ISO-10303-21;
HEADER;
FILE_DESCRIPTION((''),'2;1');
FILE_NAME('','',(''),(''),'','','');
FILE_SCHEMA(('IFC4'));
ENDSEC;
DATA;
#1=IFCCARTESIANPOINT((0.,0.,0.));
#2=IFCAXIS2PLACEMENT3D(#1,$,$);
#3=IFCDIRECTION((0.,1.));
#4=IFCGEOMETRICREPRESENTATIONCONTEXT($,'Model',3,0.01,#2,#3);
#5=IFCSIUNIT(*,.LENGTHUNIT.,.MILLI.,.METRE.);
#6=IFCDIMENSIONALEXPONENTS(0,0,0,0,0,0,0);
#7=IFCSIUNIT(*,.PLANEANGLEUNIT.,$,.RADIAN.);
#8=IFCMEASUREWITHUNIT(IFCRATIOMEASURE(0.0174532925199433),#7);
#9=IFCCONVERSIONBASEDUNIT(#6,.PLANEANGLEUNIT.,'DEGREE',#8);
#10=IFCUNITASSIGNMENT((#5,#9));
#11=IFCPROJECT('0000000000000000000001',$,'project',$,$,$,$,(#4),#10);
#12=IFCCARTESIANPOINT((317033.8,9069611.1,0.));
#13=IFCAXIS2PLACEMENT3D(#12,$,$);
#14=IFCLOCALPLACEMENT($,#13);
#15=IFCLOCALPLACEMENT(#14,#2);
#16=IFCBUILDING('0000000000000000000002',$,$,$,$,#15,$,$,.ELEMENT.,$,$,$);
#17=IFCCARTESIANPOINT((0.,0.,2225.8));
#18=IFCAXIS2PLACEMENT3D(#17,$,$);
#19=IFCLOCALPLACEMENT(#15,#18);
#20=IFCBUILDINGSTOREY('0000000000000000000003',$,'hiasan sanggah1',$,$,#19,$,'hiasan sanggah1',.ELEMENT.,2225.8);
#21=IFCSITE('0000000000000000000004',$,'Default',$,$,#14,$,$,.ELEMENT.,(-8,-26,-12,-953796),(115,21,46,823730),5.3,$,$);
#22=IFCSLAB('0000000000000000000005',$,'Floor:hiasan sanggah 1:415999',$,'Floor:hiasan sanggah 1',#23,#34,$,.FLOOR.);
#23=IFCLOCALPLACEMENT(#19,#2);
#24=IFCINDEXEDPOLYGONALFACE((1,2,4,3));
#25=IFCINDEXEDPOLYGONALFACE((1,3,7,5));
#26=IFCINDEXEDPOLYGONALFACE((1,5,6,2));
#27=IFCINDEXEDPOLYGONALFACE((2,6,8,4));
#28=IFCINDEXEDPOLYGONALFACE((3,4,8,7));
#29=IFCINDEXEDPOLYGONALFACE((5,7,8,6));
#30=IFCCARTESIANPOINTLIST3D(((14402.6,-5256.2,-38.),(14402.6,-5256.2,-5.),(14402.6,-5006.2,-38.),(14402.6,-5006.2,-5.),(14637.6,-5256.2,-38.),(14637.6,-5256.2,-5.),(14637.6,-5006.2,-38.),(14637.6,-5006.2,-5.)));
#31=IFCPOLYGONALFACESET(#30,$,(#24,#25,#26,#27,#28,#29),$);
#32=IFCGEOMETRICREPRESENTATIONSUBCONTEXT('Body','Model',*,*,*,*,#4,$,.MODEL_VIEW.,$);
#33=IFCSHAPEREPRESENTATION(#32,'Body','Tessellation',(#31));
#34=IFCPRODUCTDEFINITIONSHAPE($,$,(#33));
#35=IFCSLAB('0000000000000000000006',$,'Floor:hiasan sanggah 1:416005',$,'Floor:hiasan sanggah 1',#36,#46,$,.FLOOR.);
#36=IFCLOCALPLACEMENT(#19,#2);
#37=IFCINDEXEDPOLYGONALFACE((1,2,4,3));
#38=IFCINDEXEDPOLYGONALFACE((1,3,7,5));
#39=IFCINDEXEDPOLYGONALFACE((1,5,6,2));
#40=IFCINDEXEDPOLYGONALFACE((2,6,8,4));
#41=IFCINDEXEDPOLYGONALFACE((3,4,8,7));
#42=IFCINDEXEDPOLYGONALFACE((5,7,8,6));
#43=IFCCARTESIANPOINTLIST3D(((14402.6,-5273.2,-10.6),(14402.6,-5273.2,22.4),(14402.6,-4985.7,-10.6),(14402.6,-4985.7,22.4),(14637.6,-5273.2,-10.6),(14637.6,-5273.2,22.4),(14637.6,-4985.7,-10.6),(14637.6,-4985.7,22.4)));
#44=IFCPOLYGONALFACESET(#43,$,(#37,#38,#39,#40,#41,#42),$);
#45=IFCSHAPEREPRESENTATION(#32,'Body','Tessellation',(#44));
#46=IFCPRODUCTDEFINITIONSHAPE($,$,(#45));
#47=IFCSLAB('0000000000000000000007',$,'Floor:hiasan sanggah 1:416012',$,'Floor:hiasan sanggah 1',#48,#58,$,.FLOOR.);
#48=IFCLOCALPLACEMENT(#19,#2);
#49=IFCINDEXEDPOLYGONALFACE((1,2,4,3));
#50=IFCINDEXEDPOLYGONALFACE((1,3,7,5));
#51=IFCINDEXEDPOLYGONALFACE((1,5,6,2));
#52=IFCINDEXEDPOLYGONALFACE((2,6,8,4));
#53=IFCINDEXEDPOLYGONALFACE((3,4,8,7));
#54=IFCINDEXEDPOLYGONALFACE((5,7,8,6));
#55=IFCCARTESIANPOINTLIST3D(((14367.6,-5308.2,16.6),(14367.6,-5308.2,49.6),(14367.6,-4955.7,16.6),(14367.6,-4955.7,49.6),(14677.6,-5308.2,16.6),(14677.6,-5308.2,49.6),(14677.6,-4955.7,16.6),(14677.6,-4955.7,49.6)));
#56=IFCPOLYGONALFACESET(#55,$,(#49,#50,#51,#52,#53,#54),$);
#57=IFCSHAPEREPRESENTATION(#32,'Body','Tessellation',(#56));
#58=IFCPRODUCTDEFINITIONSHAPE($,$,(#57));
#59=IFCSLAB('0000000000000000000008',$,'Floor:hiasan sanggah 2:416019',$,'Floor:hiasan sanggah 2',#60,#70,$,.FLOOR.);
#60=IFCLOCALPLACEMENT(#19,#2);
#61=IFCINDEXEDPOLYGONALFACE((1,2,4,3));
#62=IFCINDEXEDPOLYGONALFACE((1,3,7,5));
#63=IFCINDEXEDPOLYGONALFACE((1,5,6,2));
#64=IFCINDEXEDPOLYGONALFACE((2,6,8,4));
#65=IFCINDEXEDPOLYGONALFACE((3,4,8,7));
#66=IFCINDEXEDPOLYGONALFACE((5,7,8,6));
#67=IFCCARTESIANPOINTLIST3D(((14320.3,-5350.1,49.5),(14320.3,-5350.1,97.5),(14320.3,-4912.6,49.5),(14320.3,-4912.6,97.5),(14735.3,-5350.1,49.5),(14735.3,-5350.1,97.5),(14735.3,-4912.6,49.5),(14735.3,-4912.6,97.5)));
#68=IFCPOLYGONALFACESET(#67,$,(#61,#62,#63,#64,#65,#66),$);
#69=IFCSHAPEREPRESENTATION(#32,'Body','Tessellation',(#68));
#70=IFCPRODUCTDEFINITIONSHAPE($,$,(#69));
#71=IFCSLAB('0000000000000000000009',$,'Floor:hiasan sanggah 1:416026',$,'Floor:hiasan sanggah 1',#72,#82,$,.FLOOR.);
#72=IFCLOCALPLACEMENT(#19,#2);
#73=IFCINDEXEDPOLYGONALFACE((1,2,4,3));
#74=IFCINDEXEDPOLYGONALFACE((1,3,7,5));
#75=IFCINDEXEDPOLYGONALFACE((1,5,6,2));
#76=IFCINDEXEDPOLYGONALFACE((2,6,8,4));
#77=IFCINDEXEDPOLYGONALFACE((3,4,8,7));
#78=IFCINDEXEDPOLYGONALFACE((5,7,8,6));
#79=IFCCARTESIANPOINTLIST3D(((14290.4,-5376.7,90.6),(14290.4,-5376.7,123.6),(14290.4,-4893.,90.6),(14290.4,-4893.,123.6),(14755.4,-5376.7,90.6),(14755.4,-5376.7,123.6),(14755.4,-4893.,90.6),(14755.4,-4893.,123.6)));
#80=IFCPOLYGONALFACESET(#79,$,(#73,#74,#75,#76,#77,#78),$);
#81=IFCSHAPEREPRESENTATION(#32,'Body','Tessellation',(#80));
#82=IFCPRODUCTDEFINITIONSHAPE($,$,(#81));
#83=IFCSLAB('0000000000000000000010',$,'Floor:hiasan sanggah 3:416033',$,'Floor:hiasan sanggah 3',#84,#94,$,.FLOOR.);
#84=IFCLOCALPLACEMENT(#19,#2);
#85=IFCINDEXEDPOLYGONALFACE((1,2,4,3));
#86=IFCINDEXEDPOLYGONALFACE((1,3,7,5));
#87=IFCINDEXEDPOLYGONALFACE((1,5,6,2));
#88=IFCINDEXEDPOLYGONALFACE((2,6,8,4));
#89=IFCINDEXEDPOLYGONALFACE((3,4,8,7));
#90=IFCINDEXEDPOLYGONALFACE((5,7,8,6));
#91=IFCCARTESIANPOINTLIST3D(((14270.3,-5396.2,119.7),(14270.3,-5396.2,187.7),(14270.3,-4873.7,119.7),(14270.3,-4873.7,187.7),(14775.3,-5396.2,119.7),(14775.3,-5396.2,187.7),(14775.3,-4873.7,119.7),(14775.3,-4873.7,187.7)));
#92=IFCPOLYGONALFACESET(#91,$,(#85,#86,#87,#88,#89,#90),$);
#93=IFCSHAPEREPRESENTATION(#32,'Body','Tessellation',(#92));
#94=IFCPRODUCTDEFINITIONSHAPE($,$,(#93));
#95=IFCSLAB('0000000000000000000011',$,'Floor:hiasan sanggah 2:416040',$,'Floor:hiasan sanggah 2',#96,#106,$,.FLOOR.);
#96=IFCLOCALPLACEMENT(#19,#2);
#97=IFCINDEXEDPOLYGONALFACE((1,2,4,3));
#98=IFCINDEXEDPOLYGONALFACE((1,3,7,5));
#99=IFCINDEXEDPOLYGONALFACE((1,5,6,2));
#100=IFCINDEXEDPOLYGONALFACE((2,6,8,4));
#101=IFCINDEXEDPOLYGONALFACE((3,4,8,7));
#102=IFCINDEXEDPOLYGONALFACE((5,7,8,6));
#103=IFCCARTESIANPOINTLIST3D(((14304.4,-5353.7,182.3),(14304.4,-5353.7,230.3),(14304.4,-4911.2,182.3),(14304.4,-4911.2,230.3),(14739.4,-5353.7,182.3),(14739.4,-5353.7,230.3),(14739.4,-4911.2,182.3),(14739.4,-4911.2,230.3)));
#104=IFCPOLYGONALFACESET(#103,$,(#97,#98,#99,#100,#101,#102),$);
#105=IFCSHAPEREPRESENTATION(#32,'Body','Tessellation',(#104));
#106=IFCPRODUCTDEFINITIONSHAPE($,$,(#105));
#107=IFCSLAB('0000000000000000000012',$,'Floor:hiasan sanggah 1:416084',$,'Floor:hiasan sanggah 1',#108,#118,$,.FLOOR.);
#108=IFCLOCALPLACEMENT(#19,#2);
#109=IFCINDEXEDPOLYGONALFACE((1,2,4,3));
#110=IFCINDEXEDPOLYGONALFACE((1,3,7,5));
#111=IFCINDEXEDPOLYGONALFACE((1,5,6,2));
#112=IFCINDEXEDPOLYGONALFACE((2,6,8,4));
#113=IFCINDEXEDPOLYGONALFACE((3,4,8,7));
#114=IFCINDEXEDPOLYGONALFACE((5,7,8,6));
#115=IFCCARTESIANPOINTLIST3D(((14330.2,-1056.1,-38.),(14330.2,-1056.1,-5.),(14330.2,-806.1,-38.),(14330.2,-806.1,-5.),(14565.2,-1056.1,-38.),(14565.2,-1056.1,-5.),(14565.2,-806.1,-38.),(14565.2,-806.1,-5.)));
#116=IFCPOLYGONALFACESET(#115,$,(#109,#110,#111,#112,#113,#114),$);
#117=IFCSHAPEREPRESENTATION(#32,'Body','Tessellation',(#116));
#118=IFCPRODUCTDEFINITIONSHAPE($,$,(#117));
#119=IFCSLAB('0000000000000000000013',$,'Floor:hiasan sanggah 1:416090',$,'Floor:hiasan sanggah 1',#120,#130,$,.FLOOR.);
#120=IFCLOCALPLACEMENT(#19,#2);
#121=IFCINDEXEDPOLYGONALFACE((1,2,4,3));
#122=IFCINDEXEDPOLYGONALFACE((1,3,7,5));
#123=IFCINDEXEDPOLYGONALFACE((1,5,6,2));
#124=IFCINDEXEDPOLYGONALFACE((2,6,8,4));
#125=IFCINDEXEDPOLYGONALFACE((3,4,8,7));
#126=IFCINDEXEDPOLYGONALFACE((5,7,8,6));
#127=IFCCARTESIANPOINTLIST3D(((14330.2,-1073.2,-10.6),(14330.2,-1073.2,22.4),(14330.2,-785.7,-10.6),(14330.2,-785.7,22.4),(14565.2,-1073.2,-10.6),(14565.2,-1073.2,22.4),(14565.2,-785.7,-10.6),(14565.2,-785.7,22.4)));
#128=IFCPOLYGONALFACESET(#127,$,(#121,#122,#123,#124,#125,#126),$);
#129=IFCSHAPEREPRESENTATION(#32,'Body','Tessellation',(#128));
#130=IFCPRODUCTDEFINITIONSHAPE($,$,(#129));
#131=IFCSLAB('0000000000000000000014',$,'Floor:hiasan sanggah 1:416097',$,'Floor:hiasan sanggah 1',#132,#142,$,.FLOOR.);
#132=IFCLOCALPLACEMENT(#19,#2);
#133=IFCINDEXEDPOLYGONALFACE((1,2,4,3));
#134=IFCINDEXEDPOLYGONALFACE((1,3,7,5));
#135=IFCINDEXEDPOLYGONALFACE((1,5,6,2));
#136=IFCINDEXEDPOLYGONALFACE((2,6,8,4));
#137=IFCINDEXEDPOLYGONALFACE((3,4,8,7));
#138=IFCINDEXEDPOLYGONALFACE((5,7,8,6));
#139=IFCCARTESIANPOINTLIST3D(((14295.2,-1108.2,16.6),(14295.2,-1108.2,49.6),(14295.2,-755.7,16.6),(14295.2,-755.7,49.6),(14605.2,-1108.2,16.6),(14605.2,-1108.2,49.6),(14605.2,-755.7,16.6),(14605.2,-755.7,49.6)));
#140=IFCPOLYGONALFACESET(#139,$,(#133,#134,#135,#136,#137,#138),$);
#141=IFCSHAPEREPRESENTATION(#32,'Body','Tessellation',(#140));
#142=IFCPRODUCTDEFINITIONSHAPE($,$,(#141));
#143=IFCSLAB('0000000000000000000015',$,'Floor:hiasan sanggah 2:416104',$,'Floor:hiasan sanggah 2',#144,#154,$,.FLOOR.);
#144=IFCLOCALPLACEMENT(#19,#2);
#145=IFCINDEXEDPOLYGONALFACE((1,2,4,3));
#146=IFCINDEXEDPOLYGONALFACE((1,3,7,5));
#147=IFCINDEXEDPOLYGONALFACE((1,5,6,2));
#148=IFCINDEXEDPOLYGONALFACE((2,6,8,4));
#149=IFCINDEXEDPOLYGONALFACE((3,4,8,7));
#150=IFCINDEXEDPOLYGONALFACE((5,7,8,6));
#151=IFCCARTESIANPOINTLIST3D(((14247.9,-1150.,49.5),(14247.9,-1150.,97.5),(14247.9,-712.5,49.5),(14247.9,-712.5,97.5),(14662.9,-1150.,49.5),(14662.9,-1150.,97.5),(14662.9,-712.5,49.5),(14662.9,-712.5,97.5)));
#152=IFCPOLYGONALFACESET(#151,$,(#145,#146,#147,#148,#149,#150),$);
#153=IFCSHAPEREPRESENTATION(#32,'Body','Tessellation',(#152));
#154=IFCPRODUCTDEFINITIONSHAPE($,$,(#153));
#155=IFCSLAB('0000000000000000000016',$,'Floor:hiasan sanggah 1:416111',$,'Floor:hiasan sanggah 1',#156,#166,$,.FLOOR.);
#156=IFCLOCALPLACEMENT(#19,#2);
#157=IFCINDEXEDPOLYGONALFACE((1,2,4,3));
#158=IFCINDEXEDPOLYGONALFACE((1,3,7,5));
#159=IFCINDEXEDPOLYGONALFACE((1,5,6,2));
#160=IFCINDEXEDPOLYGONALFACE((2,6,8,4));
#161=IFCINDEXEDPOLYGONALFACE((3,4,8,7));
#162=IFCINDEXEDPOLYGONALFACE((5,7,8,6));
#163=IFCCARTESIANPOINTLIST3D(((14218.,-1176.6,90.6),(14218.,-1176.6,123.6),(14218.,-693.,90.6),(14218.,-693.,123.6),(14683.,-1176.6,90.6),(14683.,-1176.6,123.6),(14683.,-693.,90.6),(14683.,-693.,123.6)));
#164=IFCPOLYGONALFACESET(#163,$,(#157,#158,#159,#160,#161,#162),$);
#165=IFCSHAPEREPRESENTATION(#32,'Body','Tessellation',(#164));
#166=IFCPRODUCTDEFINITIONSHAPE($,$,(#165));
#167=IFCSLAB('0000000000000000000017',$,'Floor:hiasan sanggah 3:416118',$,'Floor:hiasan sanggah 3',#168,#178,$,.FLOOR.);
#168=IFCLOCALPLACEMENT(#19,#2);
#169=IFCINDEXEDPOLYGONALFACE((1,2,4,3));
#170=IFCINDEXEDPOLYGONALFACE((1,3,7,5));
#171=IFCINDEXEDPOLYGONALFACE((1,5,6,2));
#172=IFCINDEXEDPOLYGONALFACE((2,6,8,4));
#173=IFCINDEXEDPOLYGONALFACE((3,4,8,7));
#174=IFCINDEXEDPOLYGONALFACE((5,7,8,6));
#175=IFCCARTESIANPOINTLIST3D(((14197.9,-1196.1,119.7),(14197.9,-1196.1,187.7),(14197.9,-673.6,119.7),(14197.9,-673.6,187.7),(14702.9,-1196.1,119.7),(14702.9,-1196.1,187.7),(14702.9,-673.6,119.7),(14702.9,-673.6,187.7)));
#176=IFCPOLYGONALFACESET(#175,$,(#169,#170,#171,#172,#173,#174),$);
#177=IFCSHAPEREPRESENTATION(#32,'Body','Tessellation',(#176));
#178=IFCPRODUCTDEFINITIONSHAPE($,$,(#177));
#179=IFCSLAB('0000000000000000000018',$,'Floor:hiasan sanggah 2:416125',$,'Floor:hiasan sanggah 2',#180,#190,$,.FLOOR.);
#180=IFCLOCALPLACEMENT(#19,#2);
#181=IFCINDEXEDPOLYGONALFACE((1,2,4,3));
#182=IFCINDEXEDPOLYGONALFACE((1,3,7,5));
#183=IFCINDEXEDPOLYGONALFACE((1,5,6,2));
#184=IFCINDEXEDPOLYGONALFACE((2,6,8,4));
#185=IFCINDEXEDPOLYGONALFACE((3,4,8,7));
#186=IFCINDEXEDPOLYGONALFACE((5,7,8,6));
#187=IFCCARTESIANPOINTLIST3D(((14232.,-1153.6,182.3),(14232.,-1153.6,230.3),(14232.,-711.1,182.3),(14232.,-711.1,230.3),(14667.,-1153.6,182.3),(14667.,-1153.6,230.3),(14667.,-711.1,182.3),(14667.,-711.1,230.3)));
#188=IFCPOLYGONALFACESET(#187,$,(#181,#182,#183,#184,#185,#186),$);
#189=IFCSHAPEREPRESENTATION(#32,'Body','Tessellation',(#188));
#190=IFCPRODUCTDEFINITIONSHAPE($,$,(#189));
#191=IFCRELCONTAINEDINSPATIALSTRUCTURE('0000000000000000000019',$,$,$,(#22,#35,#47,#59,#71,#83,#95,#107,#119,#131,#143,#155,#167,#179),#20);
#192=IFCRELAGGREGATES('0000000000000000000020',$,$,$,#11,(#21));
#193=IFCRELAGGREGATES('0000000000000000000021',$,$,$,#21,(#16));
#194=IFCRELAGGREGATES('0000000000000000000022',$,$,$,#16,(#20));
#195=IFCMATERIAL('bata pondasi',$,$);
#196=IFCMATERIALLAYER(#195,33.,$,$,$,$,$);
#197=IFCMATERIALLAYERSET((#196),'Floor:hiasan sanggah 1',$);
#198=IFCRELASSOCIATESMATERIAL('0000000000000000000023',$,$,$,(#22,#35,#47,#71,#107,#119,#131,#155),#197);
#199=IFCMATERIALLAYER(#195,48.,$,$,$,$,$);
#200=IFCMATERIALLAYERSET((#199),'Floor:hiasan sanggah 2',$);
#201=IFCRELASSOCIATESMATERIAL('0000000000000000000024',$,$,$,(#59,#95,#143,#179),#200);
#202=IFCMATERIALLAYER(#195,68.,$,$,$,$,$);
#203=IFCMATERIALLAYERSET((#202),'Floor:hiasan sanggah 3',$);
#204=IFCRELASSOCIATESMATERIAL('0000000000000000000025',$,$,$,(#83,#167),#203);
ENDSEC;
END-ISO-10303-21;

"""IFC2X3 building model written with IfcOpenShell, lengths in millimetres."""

from ifc_helpers import new_model, entity, si_unit, converted_unit, direction, frame, frame_2d, origin, origin_2d_with_axis, place, context, subcontext, project, spatial, rectangle, extrude, material, layer, layer_set, layer_usage, element, save


model = new_model("IFC2X3")

# Units and contexts
model_context = context("Model", 3, precision=0.01, world=origin(), true_north=direction((0.0, 1.0)))
body_context = subcontext(model_context, "Body", "Model", "MODEL_VIEW")
ifc_project = project(units=[si_unit("LENGTHUNIT", "METRE", prefix="MILLI"), converted_unit("PLANEANGLEUNIT", "DEGREE", entity("IfcRatioMeasure", 0.0174532925199433), si_unit("PLANEANGLEUNIT", "RADIAN"), dimensions=[0, 0, 0, 0, 0, 0, 0])], contexts=[model_context])

# Site, building, storey
site_placement = place(None, frame((317033.8, 9069611.1, 0.0)))
site = spatial("IfcSite", under=ifc_project, at=site_placement, Name="Default", CompositionType="ELEMENT", RefLatitude=(-8, -26, -12, -953796), RefLongitude=(115, 21, 46, 823730), RefElevation=5.3)
building_placement = place(site_placement, origin())
building = spatial("IfcBuilding", under=site, at=building_placement, CompositionType="ELEMENT")
storey_placement = place(building_placement, frame((0.0, 0.0, 2225.8)))
storey = spatial("IfcBuildingStorey", under=building, at=storey_placement, Name="hiasan sanggah1", LongName="hiasan sanggah1", CompositionType="ELEMENT", Elevation=2225.8)

# Slabs
ifc_material = material(Name="bata pondasi")
ifc_layer_1 = layer(ifc_material, 33.0)
ifc_layer_set_1 = layer_set([ifc_layer_1], Name="Floor:hiasan sanggah 1")
ifc_layer_2 = layer(ifc_material, 48.0)
ifc_layer_set_2 = layer_set([ifc_layer_2], Name="Floor:hiasan sanggah 2")
ifc_layer_3 = layer(ifc_material, 68.0)
ifc_layer_set_3 = layer_set([ifc_layer_3], Name="Floor:hiasan sanggah 3")
ifc_layer_usage_1 = layer_usage(ifc_layer_set_1, "AXIS3", "POSITIVE", 0.0)
slab_1_placement = place(storey_placement, origin())
element("IfcSlab", 1, at=slab_1_placement, inside=storey, material=ifc_layer_usage_1, Name="Floor:hiasan sanggah 1:415999", ObjectType="Floor:hiasan sanggah 1", PredefinedType="FLOOR", context=body_context, shape_type="SweptSolid", body=[
    extrude(rectangle(XDim=250.0, YDim=235.0, at=frame_2d((0.0, 0.0), x_axis=(1.0, 0.0))), frame((14520.1, -5131.2, -5.0), z_axis=(0.0, 0.0, -1.0), x_axis=(0.0, 1.0, 0.0)), (0.0, 0.0, 1.0), 33.0),
])
ifc_layer_usage_2 = layer_usage(ifc_layer_set_1, "AXIS3", "POSITIVE", 0.0)
slab_2_placement = place(storey_placement, origin())
element("IfcSlab", 2, at=slab_2_placement, inside=storey, material=ifc_layer_usage_2, Name="Floor:hiasan sanggah 1:416005", ObjectType="Floor:hiasan sanggah 1", PredefinedType="FLOOR", context=body_context, shape_type="SweptSolid", body=[
    extrude(rectangle(XDim=287.5, YDim=235.0, at=frame_2d((0.0, 0.0), x_axis=(1.0, 0.0))), frame((14520.1, -5129.5, 22.4), z_axis=(0.0, 0.0, -1.0), x_axis=(0.0, 1.0, 0.0)), (0.0, 0.0, 1.0), 33.0),
])
ifc_layer_usage_3 = layer_usage(ifc_layer_set_1, "AXIS3", "POSITIVE", 0.0)
slab_3_placement = place(storey_placement, origin())
element("IfcSlab", 3, at=slab_3_placement, inside=storey, material=ifc_layer_usage_3, Name="Floor:hiasan sanggah 1:416012", ObjectType="Floor:hiasan sanggah 1", PredefinedType="FLOOR", context=body_context, shape_type="SweptSolid", body=[
    extrude(rectangle(XDim=352.5, YDim=310.0, at=origin_2d_with_axis()), frame((14522.6, -5132.0, 49.6), z_axis=(0.0, 0.0, -1.0), x_axis=(0.0, 1.0, 0.0)), (0.0, 0.0, 1.0), 33.0),
])
ifc_layer_usage_4 = layer_usage(ifc_layer_set_2, "AXIS3", "POSITIVE", 0.0)
slab_4_placement = place(storey_placement, origin())
element("IfcSlab", 4, at=slab_4_placement, inside=storey, material=ifc_layer_usage_4, Name="Floor:hiasan sanggah 2:416019", ObjectType="Floor:hiasan sanggah 2", PredefinedType="FLOOR", context=body_context, shape_type="SweptSolid", body=[
    extrude(rectangle(XDim=437.5, YDim=415.0, at=frame_2d((0.0, 0.0), x_axis=(1.0, 0.0))), frame((14527.8, -5131.3, 97.5), z_axis=(0.0, 0.0, -1.0), x_axis=(0.0, 1.0, 0.0)), (0.0, 0.0, 1.0), 48.0),
])
ifc_layer_usage_5 = layer_usage(ifc_layer_set_1, "AXIS3", "POSITIVE", 0.0)
slab_5_placement = place(storey_placement, origin())
element("IfcSlab", 5, at=slab_5_placement, inside=storey, material=ifc_layer_usage_5, Name="Floor:hiasan sanggah 1:416026", ObjectType="Floor:hiasan sanggah 1", PredefinedType="FLOOR", context=body_context, shape_type="SweptSolid", body=[
    extrude(rectangle(XDim=483.7, YDim=465.0, at=frame_2d((0.0, 0.0), x_axis=(1.0, 0.0))), frame((14522.9, -5134.9, 123.6), z_axis=(0.0, 0.0, -1.0), x_axis=(0.0, 1.0, 0.0)), (0.0, 0.0, 1.0), 33.0),
])
ifc_layer_usage_6 = layer_usage(ifc_layer_set_3, "AXIS3", "POSITIVE", 0.0)
slab_6_placement = place(storey_placement, origin())
element("IfcSlab", 6, at=slab_6_placement, inside=storey, material=ifc_layer_usage_6, Name="Floor:hiasan sanggah 3:416033", ObjectType="Floor:hiasan sanggah 3", PredefinedType="FLOOR", context=body_context, shape_type="SweptSolid", body=[
    extrude(rectangle(XDim=522.5, YDim=505.0, at=origin_2d_with_axis()), frame((14522.8, -5134.9, 187.7), z_axis=(0.0, 0.0, -1.0), x_axis=(0.0, 1.0, 0.0)), (0.0, 0.0, 1.0), 68.0),
])
ifc_layer_usage_7 = layer_usage(ifc_layer_set_2, "AXIS3", "POSITIVE", 0.0)
slab_7_placement = place(storey_placement, origin())
element("IfcSlab", 7, at=slab_7_placement, inside=storey, material=ifc_layer_usage_7, Name="Floor:hiasan sanggah 2:416040", ObjectType="Floor:hiasan sanggah 2", PredefinedType="FLOOR", context=body_context, shape_type="SweptSolid", body=[
    extrude(rectangle(XDim=442.5, YDim=435.0, at=origin_2d_with_axis()), frame((14521.9, -5132.4, 230.3), z_axis=(0.0, 0.0, -1.0), x_axis=(0.0, 1.0, 0.0)), (0.0, 0.0, 1.0), 48.0),
])
ifc_layer_usage_8 = layer_usage(ifc_layer_set_1, "AXIS3", "POSITIVE", 0.0)
slab_8_placement = place(storey_placement, origin())
element("IfcSlab", 8, at=slab_8_placement, inside=storey, material=ifc_layer_usage_8, Name="Floor:hiasan sanggah 1:416084", ObjectType="Floor:hiasan sanggah 1", PredefinedType="FLOOR", context=body_context, shape_type="SweptSolid", body=[
    extrude(rectangle(XDim=250.0, YDim=235.0, at=origin_2d_with_axis()), frame((14447.7, -931.1, -5.0), z_axis=(0.0, 0.0, -1.0), x_axis=(0.0, 1.0, 0.0)), (0.0, 0.0, 1.0), 33.0),
])
ifc_layer_usage_9 = layer_usage(ifc_layer_set_1, "AXIS3", "POSITIVE", 0.0)
slab_9_placement = place(storey_placement, origin())
element("IfcSlab", 9, at=slab_9_placement, inside=storey, material=ifc_layer_usage_9, Name="Floor:hiasan sanggah 1:416090", ObjectType="Floor:hiasan sanggah 1", PredefinedType="FLOOR", context=body_context, shape_type="SweptSolid", body=[
    extrude(rectangle(XDim=287.5, YDim=235.0, at=frame_2d((0.0, 0.0), x_axis=(1.0, 0.0))), frame((14447.7, -929.4, 22.4), z_axis=(0.0, 0.0, -1.0), x_axis=(0.0, 1.0, 0.0)), (0.0, 0.0, 1.0), 33.0),
])
ifc_layer_usage_10 = layer_usage(ifc_layer_set_1, "AXIS3", "POSITIVE", 0.0)
slab_10_placement = place(storey_placement, origin())
element("IfcSlab", 10, at=slab_10_placement, inside=storey, material=ifc_layer_usage_10, Name="Floor:hiasan sanggah 1:416097", ObjectType="Floor:hiasan sanggah 1", PredefinedType="FLOOR", context=body_context, shape_type="SweptSolid", body=[
    extrude(rectangle(XDim=352.5, YDim=310.0, at=origin_2d_with_axis()), frame((14450.2, -931.9, 49.6), z_axis=(0.0, 0.0, -1.0), x_axis=(0.0, 1.0, 0.0)), (0.0, 0.0, 1.0), 33.0),
])
ifc_layer_usage_11 = layer_usage(ifc_layer_set_2, "AXIS3", "POSITIVE", 0.0)
slab_11_placement = place(storey_placement, origin())
element("IfcSlab", 11, at=slab_11_placement, inside=storey, material=ifc_layer_usage_11, Name="Floor:hiasan sanggah 2:416104", ObjectType="Floor:hiasan sanggah 2", PredefinedType="FLOOR", context=body_context, shape_type="SweptSolid", body=[
    extrude(rectangle(XDim=437.5, YDim=415.0, at=frame_2d((0.0, 0.0), x_axis=(1.0, 0.0))), frame((14455.4, -931.3, 97.5), z_axis=(0.0, 0.0, -1.0), x_axis=(0.0, 1.0, 0.0)), (0.0, 0.0, 1.0), 48.0),
])
ifc_layer_usage_12 = layer_usage(ifc_layer_set_1, "AXIS3", "POSITIVE", 0.0)
slab_12_placement = place(storey_placement, origin())
element("IfcSlab", 12, at=slab_12_placement, inside=storey, material=ifc_layer_usage_12, Name="Floor:hiasan sanggah 1:416111", ObjectType="Floor:hiasan sanggah 1", PredefinedType="FLOOR", context=body_context, shape_type="SweptSolid", body=[
    extrude(rectangle(XDim=483.7, YDim=465.0, at=origin_2d_with_axis()), frame((14450.5, -934.8, 123.6), z_axis=(0.0, 0.0, -1.0), x_axis=(0.0, 1.0, 0.0)), (0.0, 0.0, 1.0), 33.0),
])
ifc_layer_usage_13 = layer_usage(ifc_layer_set_3, "AXIS3", "POSITIVE", 0.0)
slab_13_placement = place(storey_placement, origin())
element("IfcSlab", 13, at=slab_13_placement, inside=storey, material=ifc_layer_usage_13, Name="Floor:hiasan sanggah 3:416118", ObjectType="Floor:hiasan sanggah 3", PredefinedType="FLOOR", context=body_context, shape_type="SweptSolid", body=[
    extrude(rectangle(XDim=522.5, YDim=505.0, at=frame_2d((0.0, 0.0), x_axis=(1.0, 0.0))), frame((14450.4, -934.8, 187.7), z_axis=(0.0, 0.0, -1.0), x_axis=(0.0, 1.0, 0.0)), (0.0, 0.0, 1.0), 68.0),
])
ifc_layer_usage_14 = layer_usage(ifc_layer_set_2, "AXIS3", "POSITIVE", 0.0)
slab_14_placement = place(storey_placement, origin())
element("IfcSlab", 14, at=slab_14_placement, inside=storey, material=ifc_layer_usage_14, Name="Floor:hiasan sanggah 2:416125", ObjectType="Floor:hiasan sanggah 2", PredefinedType="FLOOR", context=body_context, shape_type="SweptSolid", body=[
    extrude(rectangle(XDim=442.5, YDim=435.0, at=frame_2d((0.0, 0.0), x_axis=(1.0, 0.0))), frame((14449.5, -932.3, 230.3), z_axis=(0.0, 0.0, -1.0), x_axis=(0.0, 1.0, 0.0)), (0.0, 0.0, 1.0), 48.0),
])

save(model, "model.ifc")
